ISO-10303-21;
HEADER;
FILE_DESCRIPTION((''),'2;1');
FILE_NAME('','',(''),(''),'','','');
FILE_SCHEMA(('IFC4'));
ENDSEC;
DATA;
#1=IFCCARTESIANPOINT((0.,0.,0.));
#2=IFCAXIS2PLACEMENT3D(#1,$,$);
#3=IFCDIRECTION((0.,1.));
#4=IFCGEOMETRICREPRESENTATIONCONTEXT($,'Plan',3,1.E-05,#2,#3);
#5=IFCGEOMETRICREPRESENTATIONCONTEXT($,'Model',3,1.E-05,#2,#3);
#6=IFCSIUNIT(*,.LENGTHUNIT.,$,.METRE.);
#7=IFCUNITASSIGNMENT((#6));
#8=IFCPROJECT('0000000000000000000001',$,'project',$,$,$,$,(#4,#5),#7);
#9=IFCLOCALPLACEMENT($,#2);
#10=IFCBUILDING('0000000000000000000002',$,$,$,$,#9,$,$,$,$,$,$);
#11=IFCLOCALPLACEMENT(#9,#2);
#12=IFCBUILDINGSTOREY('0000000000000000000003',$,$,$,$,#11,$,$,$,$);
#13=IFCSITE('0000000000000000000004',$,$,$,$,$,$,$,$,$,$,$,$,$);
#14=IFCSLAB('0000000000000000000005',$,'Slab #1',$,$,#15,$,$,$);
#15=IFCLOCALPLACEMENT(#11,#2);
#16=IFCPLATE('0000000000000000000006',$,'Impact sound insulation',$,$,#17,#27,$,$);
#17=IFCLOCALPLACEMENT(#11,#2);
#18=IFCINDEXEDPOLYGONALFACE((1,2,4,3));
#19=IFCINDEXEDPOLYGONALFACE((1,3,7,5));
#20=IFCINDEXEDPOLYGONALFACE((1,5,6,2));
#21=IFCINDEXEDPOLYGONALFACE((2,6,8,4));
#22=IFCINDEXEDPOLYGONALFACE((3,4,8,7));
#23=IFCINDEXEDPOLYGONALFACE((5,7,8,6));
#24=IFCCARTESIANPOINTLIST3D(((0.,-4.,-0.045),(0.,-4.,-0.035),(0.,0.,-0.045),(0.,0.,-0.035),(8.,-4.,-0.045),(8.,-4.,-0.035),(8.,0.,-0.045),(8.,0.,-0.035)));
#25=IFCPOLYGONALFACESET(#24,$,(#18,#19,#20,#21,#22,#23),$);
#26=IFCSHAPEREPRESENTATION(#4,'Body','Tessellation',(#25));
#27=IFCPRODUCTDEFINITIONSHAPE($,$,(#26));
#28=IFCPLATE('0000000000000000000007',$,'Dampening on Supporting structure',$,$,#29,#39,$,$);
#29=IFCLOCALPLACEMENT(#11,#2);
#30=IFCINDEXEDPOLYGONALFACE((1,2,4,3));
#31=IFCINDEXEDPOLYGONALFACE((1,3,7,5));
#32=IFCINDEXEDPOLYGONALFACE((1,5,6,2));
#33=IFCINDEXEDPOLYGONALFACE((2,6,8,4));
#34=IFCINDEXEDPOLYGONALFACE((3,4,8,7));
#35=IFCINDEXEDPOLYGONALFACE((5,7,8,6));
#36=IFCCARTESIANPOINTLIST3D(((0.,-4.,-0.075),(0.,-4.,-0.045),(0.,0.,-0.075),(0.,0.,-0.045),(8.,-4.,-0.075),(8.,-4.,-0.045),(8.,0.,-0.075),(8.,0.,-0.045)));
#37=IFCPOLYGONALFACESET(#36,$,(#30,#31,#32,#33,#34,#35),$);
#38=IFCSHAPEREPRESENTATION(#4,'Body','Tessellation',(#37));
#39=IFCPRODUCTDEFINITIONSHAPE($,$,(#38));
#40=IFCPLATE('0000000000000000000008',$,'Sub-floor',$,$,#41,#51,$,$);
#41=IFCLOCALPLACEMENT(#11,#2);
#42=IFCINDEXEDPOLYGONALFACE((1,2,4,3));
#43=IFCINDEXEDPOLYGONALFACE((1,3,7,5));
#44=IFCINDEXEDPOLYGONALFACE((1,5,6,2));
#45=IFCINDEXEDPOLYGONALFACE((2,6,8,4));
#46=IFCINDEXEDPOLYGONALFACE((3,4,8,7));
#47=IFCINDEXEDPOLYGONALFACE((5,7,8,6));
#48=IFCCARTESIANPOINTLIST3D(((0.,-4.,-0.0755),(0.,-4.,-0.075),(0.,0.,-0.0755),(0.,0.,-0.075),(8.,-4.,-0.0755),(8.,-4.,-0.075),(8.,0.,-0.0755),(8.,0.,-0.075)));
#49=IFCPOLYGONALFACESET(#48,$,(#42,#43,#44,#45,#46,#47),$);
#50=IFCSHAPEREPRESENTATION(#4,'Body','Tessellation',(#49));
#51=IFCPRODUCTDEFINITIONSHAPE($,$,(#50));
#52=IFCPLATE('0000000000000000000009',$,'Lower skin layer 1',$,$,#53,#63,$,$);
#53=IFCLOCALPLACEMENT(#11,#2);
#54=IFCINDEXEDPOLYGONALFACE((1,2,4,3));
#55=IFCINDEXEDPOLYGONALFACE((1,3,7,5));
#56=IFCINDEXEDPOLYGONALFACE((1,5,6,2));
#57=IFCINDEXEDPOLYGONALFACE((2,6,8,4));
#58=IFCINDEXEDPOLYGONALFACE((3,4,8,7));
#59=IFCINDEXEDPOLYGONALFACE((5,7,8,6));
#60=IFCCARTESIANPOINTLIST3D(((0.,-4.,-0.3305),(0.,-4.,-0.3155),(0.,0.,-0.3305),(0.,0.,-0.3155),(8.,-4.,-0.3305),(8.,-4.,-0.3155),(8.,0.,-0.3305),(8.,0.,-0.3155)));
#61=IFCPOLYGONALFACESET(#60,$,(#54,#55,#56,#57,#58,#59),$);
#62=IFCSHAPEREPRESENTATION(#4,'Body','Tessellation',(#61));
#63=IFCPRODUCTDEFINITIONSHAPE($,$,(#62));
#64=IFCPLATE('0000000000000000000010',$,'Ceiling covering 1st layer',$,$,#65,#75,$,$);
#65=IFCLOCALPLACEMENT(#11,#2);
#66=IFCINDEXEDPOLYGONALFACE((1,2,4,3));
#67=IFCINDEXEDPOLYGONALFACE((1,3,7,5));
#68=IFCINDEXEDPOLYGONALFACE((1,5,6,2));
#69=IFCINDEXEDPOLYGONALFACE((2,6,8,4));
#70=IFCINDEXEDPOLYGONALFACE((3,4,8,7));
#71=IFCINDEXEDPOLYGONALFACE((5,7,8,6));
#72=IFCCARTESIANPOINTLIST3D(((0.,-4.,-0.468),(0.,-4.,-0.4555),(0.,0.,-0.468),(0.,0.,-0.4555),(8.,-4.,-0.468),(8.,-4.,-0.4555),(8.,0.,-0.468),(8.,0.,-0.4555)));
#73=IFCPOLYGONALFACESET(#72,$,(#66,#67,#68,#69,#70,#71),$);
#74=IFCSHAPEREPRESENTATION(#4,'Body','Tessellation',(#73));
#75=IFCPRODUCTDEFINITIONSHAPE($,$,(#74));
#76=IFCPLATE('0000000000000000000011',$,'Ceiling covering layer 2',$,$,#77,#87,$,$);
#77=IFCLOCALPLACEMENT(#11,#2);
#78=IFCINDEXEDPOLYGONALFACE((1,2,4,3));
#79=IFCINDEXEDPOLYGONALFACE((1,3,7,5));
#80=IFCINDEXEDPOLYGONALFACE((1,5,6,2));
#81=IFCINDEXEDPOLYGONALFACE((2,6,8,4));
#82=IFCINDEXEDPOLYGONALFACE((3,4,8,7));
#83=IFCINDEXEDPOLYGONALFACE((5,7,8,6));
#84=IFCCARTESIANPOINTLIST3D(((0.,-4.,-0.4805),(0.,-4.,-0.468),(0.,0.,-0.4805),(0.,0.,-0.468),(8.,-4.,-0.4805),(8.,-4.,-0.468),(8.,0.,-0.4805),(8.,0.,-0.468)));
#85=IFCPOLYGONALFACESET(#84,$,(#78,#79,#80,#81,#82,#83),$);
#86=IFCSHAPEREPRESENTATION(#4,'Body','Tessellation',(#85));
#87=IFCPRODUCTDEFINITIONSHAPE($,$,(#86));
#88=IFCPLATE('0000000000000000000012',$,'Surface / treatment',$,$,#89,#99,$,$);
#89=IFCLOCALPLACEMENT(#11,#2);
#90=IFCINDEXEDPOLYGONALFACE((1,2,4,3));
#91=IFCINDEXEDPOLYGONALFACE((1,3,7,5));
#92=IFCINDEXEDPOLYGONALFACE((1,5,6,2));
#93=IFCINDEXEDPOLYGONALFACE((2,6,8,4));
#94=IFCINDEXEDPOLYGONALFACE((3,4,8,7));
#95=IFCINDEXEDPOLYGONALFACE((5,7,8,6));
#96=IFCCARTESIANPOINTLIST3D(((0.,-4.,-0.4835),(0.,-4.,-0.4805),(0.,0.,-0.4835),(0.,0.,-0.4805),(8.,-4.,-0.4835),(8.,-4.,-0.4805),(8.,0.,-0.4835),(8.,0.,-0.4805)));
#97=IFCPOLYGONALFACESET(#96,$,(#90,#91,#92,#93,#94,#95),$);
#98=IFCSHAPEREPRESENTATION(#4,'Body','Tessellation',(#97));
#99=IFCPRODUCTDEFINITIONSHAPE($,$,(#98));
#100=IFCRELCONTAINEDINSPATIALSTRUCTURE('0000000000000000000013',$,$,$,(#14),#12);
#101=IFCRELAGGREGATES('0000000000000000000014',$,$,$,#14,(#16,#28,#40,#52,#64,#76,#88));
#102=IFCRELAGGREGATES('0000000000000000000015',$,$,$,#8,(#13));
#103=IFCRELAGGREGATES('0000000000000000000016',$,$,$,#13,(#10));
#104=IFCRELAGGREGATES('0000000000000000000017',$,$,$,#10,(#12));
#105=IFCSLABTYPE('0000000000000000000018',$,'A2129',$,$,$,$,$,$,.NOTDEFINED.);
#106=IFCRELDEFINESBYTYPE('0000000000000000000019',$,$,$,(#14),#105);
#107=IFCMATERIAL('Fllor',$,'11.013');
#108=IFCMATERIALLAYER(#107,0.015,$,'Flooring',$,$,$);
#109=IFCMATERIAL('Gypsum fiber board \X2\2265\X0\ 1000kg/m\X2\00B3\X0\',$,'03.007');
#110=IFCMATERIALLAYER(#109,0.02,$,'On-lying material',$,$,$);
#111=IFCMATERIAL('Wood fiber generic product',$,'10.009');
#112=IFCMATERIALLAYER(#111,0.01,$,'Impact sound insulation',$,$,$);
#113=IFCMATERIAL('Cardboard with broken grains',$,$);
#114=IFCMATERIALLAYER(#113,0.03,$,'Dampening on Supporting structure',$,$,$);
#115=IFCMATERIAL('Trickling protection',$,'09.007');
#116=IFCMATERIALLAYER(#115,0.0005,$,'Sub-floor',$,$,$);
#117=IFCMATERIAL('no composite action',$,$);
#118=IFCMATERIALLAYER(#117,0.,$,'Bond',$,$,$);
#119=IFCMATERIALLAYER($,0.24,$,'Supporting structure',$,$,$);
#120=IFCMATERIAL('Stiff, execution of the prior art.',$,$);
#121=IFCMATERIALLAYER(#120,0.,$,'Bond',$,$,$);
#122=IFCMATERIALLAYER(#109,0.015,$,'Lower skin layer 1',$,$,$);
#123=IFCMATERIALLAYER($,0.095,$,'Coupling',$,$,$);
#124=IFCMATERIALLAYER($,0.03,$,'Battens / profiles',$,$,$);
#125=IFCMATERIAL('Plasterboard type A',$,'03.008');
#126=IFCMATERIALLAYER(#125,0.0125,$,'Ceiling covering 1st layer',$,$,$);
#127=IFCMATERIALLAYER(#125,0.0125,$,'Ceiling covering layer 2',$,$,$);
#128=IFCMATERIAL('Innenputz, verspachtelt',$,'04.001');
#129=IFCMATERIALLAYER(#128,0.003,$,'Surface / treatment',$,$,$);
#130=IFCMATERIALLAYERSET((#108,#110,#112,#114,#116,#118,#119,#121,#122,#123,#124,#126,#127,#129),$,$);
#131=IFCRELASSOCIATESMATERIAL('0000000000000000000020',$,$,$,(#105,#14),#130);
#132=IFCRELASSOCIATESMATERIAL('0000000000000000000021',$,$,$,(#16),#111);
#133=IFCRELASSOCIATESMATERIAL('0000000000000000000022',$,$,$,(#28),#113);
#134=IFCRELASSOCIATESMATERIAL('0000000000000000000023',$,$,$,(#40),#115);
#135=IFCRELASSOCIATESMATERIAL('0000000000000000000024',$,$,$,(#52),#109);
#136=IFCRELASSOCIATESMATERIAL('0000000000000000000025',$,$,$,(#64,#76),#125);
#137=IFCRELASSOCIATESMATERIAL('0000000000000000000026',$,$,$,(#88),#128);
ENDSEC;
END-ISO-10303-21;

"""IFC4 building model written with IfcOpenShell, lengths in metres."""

from ifc_helpers import new_model, si_unit, direction, frame, frame_2d, origin, place, context, project, spatial, rectangle, extrude, material, layer, layer_set, type_object, element, aggregate, save


model = new_model("IFC4")

# Units and contexts
plan_context = context("Plan", 3, precision=1e-05, world=origin(), true_north=direction((0.0, 1.0)))
model_context = context("Model", 3, precision=1e-05, world=origin(), true_north=direction((0.0, 1.0)))
ifc_project = project(units=[si_unit("LENGTHUNIT", "METRE")], contexts=[plan_context, model_context])

# Site, building, storey
site = spatial("IfcSite", under=ifc_project)
building_placement = place(None, origin())
building = spatial("IfcBuilding", under=site, at=building_placement)
storey_placement = place(building_placement, origin())
storey = spatial("IfcBuildingStorey", under=building, at=storey_placement)

# Slab, plates
ifc_material_1 = material(Name="Fllor", Category="11.013")
ifc_layer_1 = layer(ifc_material_1, 0.015, Name="Flooring")
ifc_material_2 = material(Name="Gypsum fiber board ≥ 1000kg/m³", Category="03.007")
ifc_layer_2 = layer(ifc_material_2, 0.02, Name="On-lying material")
ifc_material_3 = material(Name="Wood fiber generic product", Category="10.009")
ifc_layer_3 = layer(ifc_material_3, 0.01, Name="Impact sound insulation")
ifc_material_4 = material(Name="Cardboard with broken grains")
ifc_layer_4 = layer(ifc_material_4, 0.03, Name="Dampening on Supporting structure")
ifc_material_5 = material(Name="Trickling protection", Category="09.007")
ifc_layer_5 = layer(ifc_material_5, 0.0005, Name="Sub-floor")
ifc_material_6 = material(Name="no composite action")
ifc_layer_6 = layer(ifc_material_6, 0.0, Name="Bond")
ifc_layer_7 = layer(None, 0.24, Name="Supporting structure")
ifc_material_7 = material(Name="Stiff, execution of the prior art.")
ifc_layer_8 = layer(ifc_material_7, 0.0, Name="Bond")
ifc_layer_9 = layer(ifc_material_2, 0.015, Name="Lower skin layer 1")
ifc_layer_10 = layer(None, 0.095, Name="Coupling")
ifc_layer_11 = layer(None, 0.03, Name="Battens / profiles")
ifc_material_8 = material(Name="Plasterboard type A", Category="03.008")
ifc_layer_12 = layer(ifc_material_8, 0.0125, Name="Ceiling covering 1st layer")
ifc_layer_13 = layer(ifc_material_8, 0.0125, Name="Ceiling covering layer 2")
ifc_material_9 = material(Name="Innenputz, verspachtelt", Category="04.001")
ifc_layer_14 = layer(ifc_material_9, 0.003, Name="Surface / treatment")
ifc_layer_set = layer_set([ifc_layer_1, ifc_layer_2, ifc_layer_3, ifc_layer_4, ifc_layer_5, ifc_layer_6, ifc_layer_7, ifc_layer_8, ifc_layer_9, ifc_layer_10, ifc_layer_11, ifc_layer_12, ifc_layer_13, ifc_layer_14])
slab_type = type_object("IfcSlabType", Name="A2129", PredefinedType="NOTDEFINED", material=ifc_layer_set)
slab_placement = place(None, frame((0.0, 0.0, 0.0), z_axis=(0.0, 0.0, -1.0), x_axis=(1.0, 0.0, 0.0)))
slab = element("IfcSlab", 1, at=slab_placement, inside=storey, type_object=slab_type, material=ifc_layer_set, Name="Slab #1")
plate_1_placement = place(slab_placement, origin())
plate_1 = element("IfcPlate", 2, at=plate_1_placement, material=ifc_material_3, Name="Impact sound insulation", context=plan_context, shape_type="SweptSolid", body=[
    extrude(rectangle(XDim=8.0, YDim=4.0, at=frame_2d((4.0, 2.0), x_axis=(1.0, 0.0))), frame((0.0, 0.0, 0.035), z_axis=(0.0, 0.0, 1.0), x_axis=(1.0, 0.0, 0.0)), (0.0, 0.0, 1.0), 0.01),
])
plate_2_placement = place(slab_placement, origin())
plate_2 = element("IfcPlate", 3, at=plate_2_placement, material=ifc_material_4, Name="Dampening on Supporting structure", context=plan_context, shape_type="SweptSolid", body=[
    extrude(rectangle(XDim=8.0, YDim=4.0, at=frame_2d((4.0, 2.0), x_axis=(1.0, 0.0))), frame((0.0, 0.0, 0.045), z_axis=(0.0, 0.0, 1.0), x_axis=(1.0, 0.0, 0.0)), (0.0, 0.0, 1.0), 0.03),
])
plate_3_placement = place(slab_placement, origin())
plate_3 = element("IfcPlate", 4, at=plate_3_placement, material=ifc_material_5, Name="Sub-floor", context=plan_context, shape_type="SweptSolid", body=[
    extrude(rectangle(XDim=8.0, YDim=4.0, at=frame_2d((4.0, 2.0), x_axis=(1.0, 0.0))), frame((0.0, 0.0, 0.075), z_axis=(0.0, 0.0, 1.0), x_axis=(1.0, 0.0, 0.0)), (0.0, 0.0, 1.0), 0.0005),
])
plate_4_placement = place(slab_placement, origin())
plate_4 = element("IfcPlate", 5, at=plate_4_placement, material=ifc_material_2, Name="Lower skin layer 1", context=plan_context, shape_type="SweptSolid", body=[
    extrude(rectangle(XDim=8.0, YDim=4.0, at=frame_2d((4.0, 2.0), x_axis=(1.0, 0.0))), frame((0.0, 0.0, 0.3155), z_axis=(0.0, 0.0, 1.0), x_axis=(1.0, 0.0, 0.0)), (0.0, 0.0, 1.0), 0.015),
])
plate_5_placement = place(slab_placement, origin())
plate_5 = element("IfcPlate", 6, at=plate_5_placement, material=ifc_material_8, Name="Ceiling covering 1st layer", context=plan_context, shape_type="SweptSolid", body=[
    extrude(rectangle(XDim=8.0, YDim=4.0, at=frame_2d((4.0, 2.0), x_axis=(1.0, 0.0))), frame((0.0, 0.0, 0.4555), z_axis=(0.0, 0.0, 1.0), x_axis=(1.0, 0.0, 0.0)), (0.0, 0.0, 1.0), 0.0125),
])
plate_6_placement = place(slab_placement, origin())
plate_6 = element("IfcPlate", 7, at=plate_6_placement, material=ifc_material_8, Name="Ceiling covering layer 2", context=plan_context, shape_type="SweptSolid", body=[
    extrude(rectangle(XDim=8.0, YDim=4.0, at=frame_2d((4.0, 2.0), x_axis=(1.0, 0.0))), frame((0.0, 0.0, 0.468), z_axis=(0.0, 0.0, 1.0), x_axis=(1.0, 0.0, 0.0)), (0.0, 0.0, 1.0), 0.0125),
])
plate_7_placement = place(slab_placement, origin())
plate_7 = element("IfcPlate", 8, at=plate_7_placement, material=ifc_material_9, Name="Surface / treatment", context=plan_context, shape_type="SweptSolid", body=[
    extrude(rectangle(XDim=8.0, YDim=4.0, at=frame_2d((4.0, 2.0), x_axis=(1.0, 0.0))), frame((0.0, 0.0, 0.4805), z_axis=(0.0, 0.0, 1.0), x_axis=(1.0, 0.0, 0.0)), (0.0, 0.0, 1.0), 0.003),
])
aggregate(slab, [plate_1, plate_2, plate_3, plate_4, plate_5, plate_6, plate_7])

save(model, "model.ifc")
